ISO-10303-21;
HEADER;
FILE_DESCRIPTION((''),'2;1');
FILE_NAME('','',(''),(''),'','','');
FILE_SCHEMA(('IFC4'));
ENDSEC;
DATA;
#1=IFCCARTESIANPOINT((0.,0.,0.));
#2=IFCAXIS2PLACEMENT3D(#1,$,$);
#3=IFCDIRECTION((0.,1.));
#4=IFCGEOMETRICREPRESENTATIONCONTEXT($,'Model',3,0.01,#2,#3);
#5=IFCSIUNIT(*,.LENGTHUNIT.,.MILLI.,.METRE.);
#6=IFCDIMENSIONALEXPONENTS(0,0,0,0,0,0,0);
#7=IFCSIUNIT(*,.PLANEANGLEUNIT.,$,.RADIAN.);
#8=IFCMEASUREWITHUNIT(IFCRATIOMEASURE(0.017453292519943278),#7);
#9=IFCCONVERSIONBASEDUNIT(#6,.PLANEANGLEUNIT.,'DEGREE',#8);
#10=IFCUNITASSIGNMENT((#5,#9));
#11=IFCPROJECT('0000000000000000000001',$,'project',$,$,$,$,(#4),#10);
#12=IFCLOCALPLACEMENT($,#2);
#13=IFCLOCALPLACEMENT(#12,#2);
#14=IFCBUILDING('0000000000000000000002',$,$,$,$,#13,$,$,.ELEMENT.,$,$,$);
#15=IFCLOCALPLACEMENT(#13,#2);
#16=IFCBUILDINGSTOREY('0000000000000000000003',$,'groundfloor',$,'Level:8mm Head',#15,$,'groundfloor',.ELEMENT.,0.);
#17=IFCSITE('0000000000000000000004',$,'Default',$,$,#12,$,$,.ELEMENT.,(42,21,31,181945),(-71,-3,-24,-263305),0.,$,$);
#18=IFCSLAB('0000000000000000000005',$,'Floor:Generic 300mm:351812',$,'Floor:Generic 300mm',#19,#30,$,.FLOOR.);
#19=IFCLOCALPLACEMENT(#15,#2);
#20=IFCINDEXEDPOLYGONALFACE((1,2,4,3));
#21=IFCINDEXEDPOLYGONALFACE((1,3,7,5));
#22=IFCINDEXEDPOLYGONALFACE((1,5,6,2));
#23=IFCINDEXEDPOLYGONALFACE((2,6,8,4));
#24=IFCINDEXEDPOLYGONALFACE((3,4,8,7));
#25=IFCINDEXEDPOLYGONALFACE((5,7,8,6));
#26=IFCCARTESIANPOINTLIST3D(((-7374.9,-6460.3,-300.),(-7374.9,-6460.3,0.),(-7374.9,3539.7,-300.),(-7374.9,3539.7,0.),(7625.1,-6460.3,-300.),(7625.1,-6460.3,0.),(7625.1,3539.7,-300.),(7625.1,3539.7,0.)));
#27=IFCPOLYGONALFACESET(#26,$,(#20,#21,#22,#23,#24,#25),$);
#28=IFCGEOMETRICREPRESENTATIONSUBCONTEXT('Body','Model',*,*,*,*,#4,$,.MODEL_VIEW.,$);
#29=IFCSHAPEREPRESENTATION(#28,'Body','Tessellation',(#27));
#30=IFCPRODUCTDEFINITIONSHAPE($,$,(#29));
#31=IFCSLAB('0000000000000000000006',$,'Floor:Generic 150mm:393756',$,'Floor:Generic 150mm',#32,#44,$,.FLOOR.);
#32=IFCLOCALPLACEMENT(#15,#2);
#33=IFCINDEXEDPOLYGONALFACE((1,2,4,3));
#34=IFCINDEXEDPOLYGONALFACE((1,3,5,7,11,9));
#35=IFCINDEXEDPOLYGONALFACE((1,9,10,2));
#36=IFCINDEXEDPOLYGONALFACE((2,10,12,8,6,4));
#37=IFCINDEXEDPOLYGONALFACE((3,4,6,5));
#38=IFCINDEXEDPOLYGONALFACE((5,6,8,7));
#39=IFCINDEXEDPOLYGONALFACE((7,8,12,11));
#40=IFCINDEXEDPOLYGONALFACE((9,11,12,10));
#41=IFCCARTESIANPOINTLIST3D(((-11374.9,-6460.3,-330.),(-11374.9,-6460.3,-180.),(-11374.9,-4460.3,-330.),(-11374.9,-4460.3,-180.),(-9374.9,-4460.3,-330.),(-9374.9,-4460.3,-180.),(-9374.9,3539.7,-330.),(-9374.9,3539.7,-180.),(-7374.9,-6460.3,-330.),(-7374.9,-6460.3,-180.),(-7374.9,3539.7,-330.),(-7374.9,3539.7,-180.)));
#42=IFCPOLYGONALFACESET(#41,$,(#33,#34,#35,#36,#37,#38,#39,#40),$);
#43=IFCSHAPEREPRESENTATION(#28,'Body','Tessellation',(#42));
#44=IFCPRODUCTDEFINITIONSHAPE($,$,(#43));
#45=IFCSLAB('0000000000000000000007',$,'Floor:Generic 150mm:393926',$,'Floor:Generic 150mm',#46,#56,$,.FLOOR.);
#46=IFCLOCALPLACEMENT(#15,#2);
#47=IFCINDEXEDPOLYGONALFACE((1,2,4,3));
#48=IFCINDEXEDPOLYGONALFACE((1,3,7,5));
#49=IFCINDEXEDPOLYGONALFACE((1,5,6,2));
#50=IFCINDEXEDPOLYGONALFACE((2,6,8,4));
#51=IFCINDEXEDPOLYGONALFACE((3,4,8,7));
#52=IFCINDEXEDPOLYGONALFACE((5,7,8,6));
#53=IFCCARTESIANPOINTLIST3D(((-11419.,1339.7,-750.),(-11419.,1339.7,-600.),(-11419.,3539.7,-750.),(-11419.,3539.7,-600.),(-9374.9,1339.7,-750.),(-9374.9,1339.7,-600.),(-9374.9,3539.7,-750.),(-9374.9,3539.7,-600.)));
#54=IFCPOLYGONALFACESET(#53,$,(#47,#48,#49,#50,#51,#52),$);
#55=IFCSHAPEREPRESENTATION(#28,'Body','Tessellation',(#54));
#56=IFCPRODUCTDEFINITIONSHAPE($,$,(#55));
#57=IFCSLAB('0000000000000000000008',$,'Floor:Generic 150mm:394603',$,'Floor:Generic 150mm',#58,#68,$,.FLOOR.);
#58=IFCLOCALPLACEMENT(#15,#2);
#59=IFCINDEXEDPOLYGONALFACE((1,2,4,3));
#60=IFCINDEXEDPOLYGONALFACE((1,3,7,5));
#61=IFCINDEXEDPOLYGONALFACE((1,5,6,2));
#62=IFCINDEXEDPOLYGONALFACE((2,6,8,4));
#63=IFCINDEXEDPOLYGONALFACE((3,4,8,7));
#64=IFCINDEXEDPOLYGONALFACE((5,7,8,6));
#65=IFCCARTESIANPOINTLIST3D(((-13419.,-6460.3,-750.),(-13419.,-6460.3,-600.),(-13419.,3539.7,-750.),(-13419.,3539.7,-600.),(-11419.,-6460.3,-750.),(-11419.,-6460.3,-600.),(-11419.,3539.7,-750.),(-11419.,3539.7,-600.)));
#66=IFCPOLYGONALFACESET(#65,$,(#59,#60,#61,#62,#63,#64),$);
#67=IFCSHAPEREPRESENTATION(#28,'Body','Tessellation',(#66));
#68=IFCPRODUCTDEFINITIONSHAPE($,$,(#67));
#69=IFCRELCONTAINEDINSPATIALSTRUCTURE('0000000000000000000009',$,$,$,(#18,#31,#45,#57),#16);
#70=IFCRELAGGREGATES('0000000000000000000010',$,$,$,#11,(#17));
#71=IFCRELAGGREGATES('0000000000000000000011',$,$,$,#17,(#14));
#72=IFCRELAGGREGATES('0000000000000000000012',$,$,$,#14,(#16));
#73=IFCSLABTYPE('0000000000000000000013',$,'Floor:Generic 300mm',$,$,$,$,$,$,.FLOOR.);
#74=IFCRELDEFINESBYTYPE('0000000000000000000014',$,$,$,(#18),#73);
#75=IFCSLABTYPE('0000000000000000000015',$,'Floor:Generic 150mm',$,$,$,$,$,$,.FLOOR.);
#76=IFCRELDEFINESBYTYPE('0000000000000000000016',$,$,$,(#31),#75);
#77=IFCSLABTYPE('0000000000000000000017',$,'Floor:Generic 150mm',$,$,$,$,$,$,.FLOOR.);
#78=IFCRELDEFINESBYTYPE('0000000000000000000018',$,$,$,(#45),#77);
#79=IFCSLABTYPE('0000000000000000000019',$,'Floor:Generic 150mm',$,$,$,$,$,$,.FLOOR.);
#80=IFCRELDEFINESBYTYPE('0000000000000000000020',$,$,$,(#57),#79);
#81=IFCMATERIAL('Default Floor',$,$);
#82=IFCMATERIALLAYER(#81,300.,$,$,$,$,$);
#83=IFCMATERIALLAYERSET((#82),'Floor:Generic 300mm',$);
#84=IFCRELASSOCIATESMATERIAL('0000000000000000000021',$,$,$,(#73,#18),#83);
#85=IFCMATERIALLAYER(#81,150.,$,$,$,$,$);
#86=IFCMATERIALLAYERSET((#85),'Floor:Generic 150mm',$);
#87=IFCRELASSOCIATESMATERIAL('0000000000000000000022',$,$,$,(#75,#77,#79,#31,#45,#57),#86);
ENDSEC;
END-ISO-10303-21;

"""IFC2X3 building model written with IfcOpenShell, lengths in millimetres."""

from ifc_helpers import new_model, entity, si_unit, converted_unit, direction, frame, frame_2d, origin, origin_2d_with_axis, place, context, subcontext, project, spatial, polyline, rectangle, outline, extrude, material, layer, layer_set, layer_usage, type_object, element, save


model = new_model("IFC2X3")

# Units and contexts
model_context = context("Model", 3, precision=0.01, world=origin(), true_north=direction((0.0, 1.0)))
body_context = subcontext(model_context, "Body", "Model", "MODEL_VIEW")
ifc_project = project(units=[si_unit("LENGTHUNIT", "METRE", prefix="MILLI"), converted_unit("PLANEANGLEUNIT", "DEGREE", entity("IfcRatioMeasure", 0.017453292519943278), si_unit("PLANEANGLEUNIT", "RADIAN"), dimensions=[0, 0, 0, 0, 0, 0, 0])], contexts=[model_context])

# Site, building, storey
site_placement = place(None, origin())
site = spatial("IfcSite", under=ifc_project, at=site_placement, Name="Default", CompositionType="ELEMENT", RefLatitude=(42, 21, 31, 181945), RefLongitude=(-71, -3, -24, -263305), RefElevation=0.0)
building_placement = place(site_placement, origin())
building = spatial("IfcBuilding", under=site, at=building_placement, CompositionType="ELEMENT")
storey_placement = place(building_placement, origin())
storey = spatial("IfcBuildingStorey", under=building, at=storey_placement, Name="groundfloor", ObjectType="Level:8mm Head", LongName="groundfloor", CompositionType="ELEMENT", Elevation=0.0)

# Slabs
ifc_material_1 = material(Name="Default Floor")
ifc_layer_1 = layer(ifc_material_1, 300.0)
ifc_layer_set_1 = layer_set([ifc_layer_1], Name="Floor:Generic 300mm")
ifc_layer_usage_1 = layer_usage(ifc_layer_set_1, "AXIS3", "POSITIVE", 0.0)
slab_type_1 = type_object("IfcSlabType", Name="Floor:Generic 300mm", PredefinedType="FLOOR", material=ifc_layer_set_1)
slab_1_placement = place(storey_placement, origin())
element("IfcSlab", 1, at=slab_1_placement, inside=storey, type_object=slab_type_1, material=ifc_layer_usage_1, Name="Floor:Generic 300mm:351812", ObjectType="Floor:Generic 300mm", PredefinedType="FLOOR", context=body_context, shape_type="SweptSolid", body=[
    extrude(rectangle(XDim=10000.0, YDim=15000.0, at=origin_2d_with_axis()), frame((125.1, -1460.3, 0.0), z_axis=(0.0, 0.0, -1.0), x_axis=(0.0, 1.0, 0.0)), (0.0, 0.0, 1.0), 300.0),
])
ifc_layer_2 = layer(ifc_material_1, 150.0)
ifc_layer_set_2 = layer_set([ifc_layer_2], Name="Floor:Generic 150mm")
ifc_layer_usage_2 = layer_usage(ifc_layer_set_2, "AXIS3", "POSITIVE", 0.0)
slab_type_2 = type_object("IfcSlabType", Name="Floor:Generic 150mm", PredefinedType="FLOOR", material=ifc_layer_set_2)
slab_2_placement = place(storey_placement, origin())
element("IfcSlab", 2, at=slab_2_placement, inside=storey, type_object=slab_type_2, material=ifc_layer_usage_2, Name="Floor:Generic 150mm:393756", ObjectType="Floor:Generic 150mm", PredefinedType="FLOOR", context=body_context, shape_type="SweptSolid", body=[
    extrude(outline(polyline([(-4000.0, -2000.0), (-2000.0, -2000.0), (-2000.0, 0.0), (6000.0, 0.0), (6000.0, 2000.0), (-4000.0, 2000.0), (-4000.0, -2000.0)])), frame((-9374.9, -2460.3, -180.0), z_axis=(0.0, 0.0, -1.0), x_axis=(0.0, 1.0, 0.0)), (0.0, 0.0, 1.0), 150.0),
])
ifc_layer_usage_3 = layer_usage(ifc_layer_set_2, "AXIS3", "POSITIVE", 0.0)
slab_type_3 = type_object("IfcSlabType", Name="Floor:Generic 150mm", PredefinedType="FLOOR", material=ifc_layer_set_2)
slab_3_placement = place(storey_placement, origin())
element("IfcSlab", 3, at=slab_3_placement, inside=storey, type_object=slab_type_3, material=ifc_layer_usage_3, Name="Floor:Generic 150mm:393926", ObjectType="Floor:Generic 150mm", PredefinedType="FLOOR", context=body_context, shape_type="SweptSolid", body=[
    extrude(rectangle(XDim=2200.0, YDim=2044.0, at=frame_2d((0.0, 0.0), x_axis=(1.0, 0.0))), frame((-10397.0, 2439.7, -600.0), z_axis=(0.0, 0.0, -1.0), x_axis=(0.0, 1.0, 0.0)), (0.0, 0.0, 1.0), 150.0),
])
ifc_layer_usage_4 = layer_usage(ifc_layer_set_2, "AXIS3", "POSITIVE", 0.0)
slab_type_4 = type_object("IfcSlabType", Name="Floor:Generic 150mm", PredefinedType="FLOOR", material=ifc_layer_set_2)
slab_4_placement = place(storey_placement, origin())
element("IfcSlab", 4, at=slab_4_placement, inside=storey, type_object=slab_type_4, material=ifc_layer_usage_4, Name="Floor:Generic 150mm:394603", ObjectType="Floor:Generic 150mm", PredefinedType="FLOOR", context=body_context, shape_type="SweptSolid", body=[
    extrude(rectangle(XDim=10000.0, YDim=2000.0, at=frame_2d((0.0, 0.0), x_axis=(1.0, 0.0))), frame((-12419.0, -1460.3, -600.0), z_axis=(0.0, 0.0, -1.0), x_axis=(0.0, 1.0, 0.0)), (0.0, 0.0, 1.0), 150.0),
])

save(model, "model.ifc")
